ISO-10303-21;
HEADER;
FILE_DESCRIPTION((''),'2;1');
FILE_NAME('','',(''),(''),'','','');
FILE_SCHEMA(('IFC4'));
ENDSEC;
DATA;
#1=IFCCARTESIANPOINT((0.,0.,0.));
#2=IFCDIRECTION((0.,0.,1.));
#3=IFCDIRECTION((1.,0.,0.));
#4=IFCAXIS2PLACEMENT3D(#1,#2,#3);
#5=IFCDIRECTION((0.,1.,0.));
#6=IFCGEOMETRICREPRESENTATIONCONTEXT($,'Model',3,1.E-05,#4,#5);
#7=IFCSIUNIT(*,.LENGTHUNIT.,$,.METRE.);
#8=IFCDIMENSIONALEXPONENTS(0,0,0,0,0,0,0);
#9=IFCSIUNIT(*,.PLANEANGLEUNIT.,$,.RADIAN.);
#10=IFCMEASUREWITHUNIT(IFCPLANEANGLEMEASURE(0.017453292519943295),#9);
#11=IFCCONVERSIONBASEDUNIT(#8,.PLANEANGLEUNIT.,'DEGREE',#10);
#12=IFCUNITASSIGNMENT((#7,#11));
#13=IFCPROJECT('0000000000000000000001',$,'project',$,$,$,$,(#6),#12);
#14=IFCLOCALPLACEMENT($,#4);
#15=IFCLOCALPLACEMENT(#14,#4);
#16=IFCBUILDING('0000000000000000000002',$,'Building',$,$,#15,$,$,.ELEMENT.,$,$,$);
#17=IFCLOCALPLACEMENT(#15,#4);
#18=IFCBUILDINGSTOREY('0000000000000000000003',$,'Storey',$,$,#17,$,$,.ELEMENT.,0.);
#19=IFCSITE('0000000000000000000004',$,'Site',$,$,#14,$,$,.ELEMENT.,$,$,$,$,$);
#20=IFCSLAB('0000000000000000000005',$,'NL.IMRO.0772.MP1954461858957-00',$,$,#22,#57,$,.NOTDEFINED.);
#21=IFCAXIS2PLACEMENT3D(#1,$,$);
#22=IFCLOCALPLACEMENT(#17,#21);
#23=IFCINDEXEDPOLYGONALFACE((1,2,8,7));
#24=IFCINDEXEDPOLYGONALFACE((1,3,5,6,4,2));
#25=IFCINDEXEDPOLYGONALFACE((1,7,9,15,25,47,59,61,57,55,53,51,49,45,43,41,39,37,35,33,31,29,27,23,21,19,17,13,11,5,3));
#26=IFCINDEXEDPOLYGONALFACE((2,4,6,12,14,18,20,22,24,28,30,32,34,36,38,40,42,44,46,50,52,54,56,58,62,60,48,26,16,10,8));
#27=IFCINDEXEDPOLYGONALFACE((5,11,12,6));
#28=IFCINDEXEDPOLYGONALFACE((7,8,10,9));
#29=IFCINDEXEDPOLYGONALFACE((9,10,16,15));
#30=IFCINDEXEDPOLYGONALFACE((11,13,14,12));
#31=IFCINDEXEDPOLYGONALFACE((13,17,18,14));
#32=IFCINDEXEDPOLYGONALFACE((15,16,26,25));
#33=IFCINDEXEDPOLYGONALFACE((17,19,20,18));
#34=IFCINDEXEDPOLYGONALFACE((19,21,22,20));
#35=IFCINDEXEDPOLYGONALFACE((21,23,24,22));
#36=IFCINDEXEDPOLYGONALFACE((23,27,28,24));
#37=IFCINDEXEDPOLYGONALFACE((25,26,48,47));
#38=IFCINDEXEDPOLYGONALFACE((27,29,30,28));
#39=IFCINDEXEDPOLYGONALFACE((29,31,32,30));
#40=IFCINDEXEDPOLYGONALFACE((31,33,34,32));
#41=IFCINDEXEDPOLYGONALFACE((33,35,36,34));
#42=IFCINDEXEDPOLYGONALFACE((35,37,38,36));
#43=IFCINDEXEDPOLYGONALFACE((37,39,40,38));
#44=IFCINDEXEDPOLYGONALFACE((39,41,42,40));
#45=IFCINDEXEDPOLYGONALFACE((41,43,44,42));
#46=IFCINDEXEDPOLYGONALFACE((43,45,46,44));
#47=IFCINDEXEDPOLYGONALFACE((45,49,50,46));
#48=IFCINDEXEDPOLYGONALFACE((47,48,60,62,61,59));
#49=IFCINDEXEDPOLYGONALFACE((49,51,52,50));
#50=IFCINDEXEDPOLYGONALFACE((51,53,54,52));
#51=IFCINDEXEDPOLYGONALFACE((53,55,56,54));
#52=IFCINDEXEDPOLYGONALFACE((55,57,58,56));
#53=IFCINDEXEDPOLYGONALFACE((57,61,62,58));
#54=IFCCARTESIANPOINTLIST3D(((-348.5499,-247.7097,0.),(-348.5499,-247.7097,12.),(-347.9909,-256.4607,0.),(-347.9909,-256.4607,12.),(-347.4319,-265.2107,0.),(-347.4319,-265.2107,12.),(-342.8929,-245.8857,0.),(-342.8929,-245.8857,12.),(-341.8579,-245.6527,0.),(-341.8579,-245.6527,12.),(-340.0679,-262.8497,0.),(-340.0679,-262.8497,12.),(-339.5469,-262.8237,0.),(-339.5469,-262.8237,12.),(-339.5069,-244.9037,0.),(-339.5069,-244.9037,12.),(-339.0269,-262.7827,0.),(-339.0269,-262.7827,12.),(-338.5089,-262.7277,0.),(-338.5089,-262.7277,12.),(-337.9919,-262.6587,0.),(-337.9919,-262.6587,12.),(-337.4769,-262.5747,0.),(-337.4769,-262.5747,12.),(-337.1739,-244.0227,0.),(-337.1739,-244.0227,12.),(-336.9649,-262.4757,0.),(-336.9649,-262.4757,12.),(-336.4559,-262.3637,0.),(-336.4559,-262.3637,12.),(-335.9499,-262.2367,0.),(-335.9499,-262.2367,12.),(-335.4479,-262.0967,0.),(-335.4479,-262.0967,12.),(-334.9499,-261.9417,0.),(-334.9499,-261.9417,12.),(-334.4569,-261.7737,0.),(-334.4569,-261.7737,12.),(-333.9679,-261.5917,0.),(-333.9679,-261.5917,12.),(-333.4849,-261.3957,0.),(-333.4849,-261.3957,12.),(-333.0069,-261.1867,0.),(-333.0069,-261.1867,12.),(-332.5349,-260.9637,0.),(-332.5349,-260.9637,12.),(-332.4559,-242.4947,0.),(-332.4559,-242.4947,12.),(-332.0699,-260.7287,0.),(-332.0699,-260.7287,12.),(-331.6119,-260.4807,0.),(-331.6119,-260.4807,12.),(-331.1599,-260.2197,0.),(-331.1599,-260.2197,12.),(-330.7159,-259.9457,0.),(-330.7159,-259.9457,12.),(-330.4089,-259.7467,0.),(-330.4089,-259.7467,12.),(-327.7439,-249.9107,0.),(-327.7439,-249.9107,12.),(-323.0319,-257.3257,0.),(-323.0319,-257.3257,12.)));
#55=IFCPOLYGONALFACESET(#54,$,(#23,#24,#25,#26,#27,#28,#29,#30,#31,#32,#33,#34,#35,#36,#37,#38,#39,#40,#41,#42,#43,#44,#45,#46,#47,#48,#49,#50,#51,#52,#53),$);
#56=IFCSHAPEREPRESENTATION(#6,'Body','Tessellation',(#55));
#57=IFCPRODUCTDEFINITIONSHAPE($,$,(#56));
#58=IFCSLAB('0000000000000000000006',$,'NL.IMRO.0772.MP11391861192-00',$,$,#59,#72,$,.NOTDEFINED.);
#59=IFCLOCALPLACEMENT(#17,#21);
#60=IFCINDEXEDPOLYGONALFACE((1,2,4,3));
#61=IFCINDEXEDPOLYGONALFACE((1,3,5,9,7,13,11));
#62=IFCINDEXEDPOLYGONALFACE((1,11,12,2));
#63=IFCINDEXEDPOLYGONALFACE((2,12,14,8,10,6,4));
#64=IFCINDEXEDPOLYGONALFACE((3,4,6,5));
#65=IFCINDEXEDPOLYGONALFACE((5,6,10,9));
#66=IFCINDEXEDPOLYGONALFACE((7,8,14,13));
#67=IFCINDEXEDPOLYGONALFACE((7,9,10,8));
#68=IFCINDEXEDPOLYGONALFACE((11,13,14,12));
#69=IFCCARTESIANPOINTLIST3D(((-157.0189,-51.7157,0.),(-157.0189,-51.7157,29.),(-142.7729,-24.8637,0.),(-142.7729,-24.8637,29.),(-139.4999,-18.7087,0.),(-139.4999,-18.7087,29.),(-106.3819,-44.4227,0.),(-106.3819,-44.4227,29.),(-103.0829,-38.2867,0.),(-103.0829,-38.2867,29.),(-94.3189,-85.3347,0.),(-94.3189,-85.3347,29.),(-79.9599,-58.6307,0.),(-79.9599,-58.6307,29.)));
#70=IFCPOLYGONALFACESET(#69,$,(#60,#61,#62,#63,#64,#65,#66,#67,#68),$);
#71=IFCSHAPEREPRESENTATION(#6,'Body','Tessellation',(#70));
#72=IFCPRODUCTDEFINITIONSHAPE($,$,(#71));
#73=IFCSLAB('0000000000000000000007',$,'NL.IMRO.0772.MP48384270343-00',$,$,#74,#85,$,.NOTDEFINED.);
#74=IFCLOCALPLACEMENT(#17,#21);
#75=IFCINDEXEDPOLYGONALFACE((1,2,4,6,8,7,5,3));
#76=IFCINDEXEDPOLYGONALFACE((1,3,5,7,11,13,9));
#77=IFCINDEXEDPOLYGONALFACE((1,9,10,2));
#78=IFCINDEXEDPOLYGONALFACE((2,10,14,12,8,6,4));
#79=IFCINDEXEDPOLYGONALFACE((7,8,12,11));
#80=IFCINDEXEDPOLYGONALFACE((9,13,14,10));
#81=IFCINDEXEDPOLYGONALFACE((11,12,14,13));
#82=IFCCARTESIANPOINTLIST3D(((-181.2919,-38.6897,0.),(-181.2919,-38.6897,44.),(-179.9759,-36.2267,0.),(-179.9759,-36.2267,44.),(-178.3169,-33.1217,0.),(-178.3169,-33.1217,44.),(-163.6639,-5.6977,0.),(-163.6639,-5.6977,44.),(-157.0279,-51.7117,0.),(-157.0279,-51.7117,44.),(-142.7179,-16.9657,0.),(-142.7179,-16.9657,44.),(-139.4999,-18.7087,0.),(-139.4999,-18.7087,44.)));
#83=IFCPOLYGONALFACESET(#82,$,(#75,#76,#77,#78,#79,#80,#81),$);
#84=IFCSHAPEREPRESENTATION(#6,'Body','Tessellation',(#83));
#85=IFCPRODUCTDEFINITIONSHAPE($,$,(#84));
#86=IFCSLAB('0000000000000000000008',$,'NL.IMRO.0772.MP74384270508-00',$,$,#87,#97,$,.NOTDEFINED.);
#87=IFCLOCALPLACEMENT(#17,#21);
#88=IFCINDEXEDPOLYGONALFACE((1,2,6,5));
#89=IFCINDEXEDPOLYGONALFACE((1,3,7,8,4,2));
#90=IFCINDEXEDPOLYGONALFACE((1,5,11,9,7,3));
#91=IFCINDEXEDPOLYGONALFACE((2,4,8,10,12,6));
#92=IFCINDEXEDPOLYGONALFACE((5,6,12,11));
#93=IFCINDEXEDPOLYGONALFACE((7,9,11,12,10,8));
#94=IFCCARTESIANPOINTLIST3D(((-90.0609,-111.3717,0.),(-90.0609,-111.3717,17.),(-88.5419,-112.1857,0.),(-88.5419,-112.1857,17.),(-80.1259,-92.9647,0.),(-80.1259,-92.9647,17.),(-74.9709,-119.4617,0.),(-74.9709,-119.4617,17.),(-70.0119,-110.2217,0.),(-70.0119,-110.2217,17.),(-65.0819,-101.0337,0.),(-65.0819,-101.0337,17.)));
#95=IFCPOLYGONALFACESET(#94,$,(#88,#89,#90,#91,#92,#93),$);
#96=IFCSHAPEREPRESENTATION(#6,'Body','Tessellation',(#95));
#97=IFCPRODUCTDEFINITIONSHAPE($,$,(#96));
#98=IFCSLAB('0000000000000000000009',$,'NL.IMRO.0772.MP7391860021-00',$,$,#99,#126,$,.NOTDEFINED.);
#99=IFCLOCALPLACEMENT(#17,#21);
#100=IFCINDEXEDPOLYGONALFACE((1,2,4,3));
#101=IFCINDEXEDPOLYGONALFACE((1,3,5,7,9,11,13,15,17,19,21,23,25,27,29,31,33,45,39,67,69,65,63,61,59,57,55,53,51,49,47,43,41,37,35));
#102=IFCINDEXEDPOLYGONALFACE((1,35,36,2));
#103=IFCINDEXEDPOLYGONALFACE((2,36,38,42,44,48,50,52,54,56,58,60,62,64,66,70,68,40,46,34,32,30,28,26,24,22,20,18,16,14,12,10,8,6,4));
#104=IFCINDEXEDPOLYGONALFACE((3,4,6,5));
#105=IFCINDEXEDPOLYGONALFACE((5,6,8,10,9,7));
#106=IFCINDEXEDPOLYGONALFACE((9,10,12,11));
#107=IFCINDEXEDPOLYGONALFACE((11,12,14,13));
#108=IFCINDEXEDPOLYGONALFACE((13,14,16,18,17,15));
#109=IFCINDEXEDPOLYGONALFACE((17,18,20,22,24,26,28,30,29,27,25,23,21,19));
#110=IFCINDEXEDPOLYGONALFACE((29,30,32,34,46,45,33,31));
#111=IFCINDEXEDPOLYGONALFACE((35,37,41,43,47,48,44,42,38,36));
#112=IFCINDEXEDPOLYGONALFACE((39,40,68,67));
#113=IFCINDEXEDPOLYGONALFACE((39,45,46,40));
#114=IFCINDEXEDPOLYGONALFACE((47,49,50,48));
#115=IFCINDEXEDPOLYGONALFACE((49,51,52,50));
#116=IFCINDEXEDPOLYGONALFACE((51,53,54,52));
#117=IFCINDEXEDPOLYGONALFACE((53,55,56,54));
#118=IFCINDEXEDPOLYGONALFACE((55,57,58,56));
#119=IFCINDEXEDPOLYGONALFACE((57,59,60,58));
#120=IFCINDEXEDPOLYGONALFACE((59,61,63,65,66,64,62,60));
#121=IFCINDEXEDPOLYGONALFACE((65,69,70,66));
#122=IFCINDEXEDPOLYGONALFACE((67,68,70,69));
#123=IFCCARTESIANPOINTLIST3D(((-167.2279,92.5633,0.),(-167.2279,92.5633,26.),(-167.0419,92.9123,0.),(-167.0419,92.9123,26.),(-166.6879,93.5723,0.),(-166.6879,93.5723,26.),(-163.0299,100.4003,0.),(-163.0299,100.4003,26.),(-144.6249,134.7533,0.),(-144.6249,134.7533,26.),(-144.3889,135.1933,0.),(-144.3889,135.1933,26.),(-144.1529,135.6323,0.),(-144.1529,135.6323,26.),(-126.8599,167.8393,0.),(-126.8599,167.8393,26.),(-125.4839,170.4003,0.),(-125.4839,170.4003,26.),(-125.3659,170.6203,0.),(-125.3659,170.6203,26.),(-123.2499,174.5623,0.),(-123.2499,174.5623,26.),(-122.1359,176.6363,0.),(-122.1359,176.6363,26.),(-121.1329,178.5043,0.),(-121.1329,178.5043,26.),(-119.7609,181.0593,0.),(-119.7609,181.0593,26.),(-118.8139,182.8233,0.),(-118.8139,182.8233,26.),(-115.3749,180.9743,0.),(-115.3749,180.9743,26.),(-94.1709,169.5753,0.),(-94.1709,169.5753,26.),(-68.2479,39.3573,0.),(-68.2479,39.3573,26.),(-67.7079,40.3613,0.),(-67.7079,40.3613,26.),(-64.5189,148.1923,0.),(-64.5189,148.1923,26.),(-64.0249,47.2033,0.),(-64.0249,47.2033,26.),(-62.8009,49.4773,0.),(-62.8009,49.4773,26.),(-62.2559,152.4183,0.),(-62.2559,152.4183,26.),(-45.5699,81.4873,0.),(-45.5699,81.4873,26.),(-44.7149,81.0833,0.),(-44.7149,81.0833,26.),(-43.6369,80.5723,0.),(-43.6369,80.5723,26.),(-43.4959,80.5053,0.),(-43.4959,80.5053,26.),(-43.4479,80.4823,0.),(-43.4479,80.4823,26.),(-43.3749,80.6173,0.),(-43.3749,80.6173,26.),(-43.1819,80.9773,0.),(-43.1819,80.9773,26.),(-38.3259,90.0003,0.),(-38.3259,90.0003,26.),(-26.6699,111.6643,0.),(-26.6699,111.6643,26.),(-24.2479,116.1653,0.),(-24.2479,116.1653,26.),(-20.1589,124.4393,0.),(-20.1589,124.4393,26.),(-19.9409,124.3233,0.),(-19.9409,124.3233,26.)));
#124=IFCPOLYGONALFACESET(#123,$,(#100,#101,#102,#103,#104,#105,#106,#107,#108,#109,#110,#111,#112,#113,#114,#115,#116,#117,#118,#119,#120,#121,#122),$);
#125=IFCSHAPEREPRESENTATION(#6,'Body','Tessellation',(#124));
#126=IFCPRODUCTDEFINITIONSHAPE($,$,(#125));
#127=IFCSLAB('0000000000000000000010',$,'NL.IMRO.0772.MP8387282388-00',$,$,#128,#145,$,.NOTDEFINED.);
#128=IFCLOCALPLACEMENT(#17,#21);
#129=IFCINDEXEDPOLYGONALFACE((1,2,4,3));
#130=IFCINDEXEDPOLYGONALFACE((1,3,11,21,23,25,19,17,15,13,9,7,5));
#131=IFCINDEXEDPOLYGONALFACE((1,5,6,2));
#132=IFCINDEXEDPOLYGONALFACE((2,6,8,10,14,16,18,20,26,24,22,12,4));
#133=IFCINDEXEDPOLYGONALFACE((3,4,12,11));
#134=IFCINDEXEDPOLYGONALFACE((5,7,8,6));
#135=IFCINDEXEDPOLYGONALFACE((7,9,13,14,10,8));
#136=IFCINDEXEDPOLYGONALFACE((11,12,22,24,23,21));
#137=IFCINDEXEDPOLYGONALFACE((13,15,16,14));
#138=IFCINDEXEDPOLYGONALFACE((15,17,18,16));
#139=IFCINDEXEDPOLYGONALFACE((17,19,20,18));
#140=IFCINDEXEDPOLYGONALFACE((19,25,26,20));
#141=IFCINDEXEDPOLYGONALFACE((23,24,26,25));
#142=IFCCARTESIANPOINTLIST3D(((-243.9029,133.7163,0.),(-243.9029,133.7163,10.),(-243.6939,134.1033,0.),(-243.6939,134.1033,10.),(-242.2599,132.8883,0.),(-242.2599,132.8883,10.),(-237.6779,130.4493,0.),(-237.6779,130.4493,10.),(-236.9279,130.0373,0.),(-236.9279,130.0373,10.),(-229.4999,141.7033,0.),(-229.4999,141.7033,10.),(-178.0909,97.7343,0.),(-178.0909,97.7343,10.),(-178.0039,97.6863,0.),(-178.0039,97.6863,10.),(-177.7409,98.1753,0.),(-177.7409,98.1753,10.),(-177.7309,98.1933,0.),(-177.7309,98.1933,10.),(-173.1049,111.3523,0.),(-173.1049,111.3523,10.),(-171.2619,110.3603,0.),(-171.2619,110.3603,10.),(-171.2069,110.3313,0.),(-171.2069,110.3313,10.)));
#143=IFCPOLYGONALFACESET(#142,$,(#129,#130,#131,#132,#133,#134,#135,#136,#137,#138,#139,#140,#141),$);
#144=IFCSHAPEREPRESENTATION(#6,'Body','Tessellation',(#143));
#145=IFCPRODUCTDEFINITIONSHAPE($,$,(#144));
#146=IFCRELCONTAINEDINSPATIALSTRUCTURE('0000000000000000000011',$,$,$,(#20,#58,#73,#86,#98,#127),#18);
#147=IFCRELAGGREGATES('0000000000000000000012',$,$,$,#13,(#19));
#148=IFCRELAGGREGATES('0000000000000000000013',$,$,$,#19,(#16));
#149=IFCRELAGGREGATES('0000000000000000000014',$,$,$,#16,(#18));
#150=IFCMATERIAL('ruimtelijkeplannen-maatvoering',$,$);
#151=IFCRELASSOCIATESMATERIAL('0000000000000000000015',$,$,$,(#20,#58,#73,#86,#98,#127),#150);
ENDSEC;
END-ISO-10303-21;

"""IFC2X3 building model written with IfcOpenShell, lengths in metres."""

from ifc_helpers import new_model, entity, si_unit, converted_unit, direction, origin_with_axes, place, context, project, spatial, polyline, outline, extrude, material, element, save


model = new_model("IFC2X3")

# Units and contexts
model_context = context("Model", 3, precision=1e-05, world=origin_with_axes(), true_north=direction((0.0, 1.0, 0.0)))
ifc_project = project(units=[si_unit("LENGTHUNIT", "METRE"), converted_unit("PLANEANGLEUNIT", "DEGREE", entity("IfcPlaneAngleMeasure", 0.017453292519943295), si_unit("PLANEANGLEUNIT", "RADIAN"), dimensions=[0, 0, 0, 0, 0, 0, 0])], contexts=[model_context])

# Site, building, storey
site_placement = place(None, origin_with_axes())
site = spatial("IfcSite", under=ifc_project, at=site_placement, Name="Site", CompositionType="ELEMENT")
building_placement = place(site_placement, origin_with_axes())
building = spatial("IfcBuilding", under=site, at=building_placement, Name="Building", CompositionType="ELEMENT")
storey_placement = place(building_placement, origin_with_axes())
storey = spatial("IfcBuildingStorey", under=building, at=storey_placement, Name="Storey", CompositionType="ELEMENT", Elevation=0.0)

# Slabs
ifc_material = material(Name="ruimtelijkeplannen-maatvoering")
slab_1_placement = place(storey_placement, origin_with_axes())
element("IfcSlab", 1, at=slab_1_placement, inside=storey, material=ifc_material, Name="NL.IMRO.0772.MP1954461858957-00", PredefinedType="NOTDEFINED", context=model_context, shape_type="SweptSolid", body=[
    extrude(outline(polyline([(-331.6119, -260.4807), (-332.0699, -260.7287), (-332.5349, -260.9637), (-333.0069, -261.1867), (-333.4849, -261.3957), (-333.9679, -261.5917), (-334.4569, -261.7737), (-334.9499, -261.9417), (-335.4479, -262.0967), (-335.9499, -262.2367), (-336.4559, -262.3637), (-336.9649, -262.4757), (-337.4769, -262.5747), (-337.9919, -262.6587), (-338.5089, -262.7277), (-339.0269, -262.7827), (-339.5469, -262.8237), (-340.0679, -262.8497), (-347.4319, -265.2107), (-347.9909, -256.4607), (-348.5499, -247.7097), (-342.8929, -245.8857), (-341.8579, -245.6527), (-339.5069, -244.9037), (-337.1739, -244.0227), (-332.4559, -242.4947), (-327.7439, -249.9107), (-323.0319, -257.3257), (-330.4089, -259.7467), (-330.7159, -259.9457), (-331.1599, -260.2197), (-331.6119, -260.4807)])), origin_with_axes(), (0.0, 0.0, 1.0), 12.0),
])
slab_2_placement = place(storey_placement, origin_with_axes())
element("IfcSlab", 2, at=slab_2_placement, inside=storey, material=ifc_material, Name="NL.IMRO.0772.MP11391861192-00", PredefinedType="NOTDEFINED", context=model_context, shape_type="SweptSolid", body=[
    extrude(outline(polyline([(-142.7729, -24.8637), (-139.4999, -18.7087), (-103.0829, -38.2867), (-106.3819, -44.4227), (-79.9599, -58.6307), (-94.3189, -85.3347), (-157.0189, -51.7157), (-142.7729, -24.8637)])), origin_with_axes(), (0.0, 0.0, 1.0), 29.0),
])
slab_3_placement = place(storey_placement, origin_with_axes())
element("IfcSlab", 3, at=slab_3_placement, inside=storey, material=ifc_material, Name="NL.IMRO.0772.MP48384270343-00", PredefinedType="NOTDEFINED", context=model_context, shape_type="SweptSolid", body=[
    extrude(outline(polyline([(-157.0279, -51.7117), (-181.2919, -38.6897), (-179.9759, -36.2267), (-178.3169, -33.1217), (-163.6639, -5.6977), (-142.7179, -16.9657), (-139.4999, -18.7087), (-157.0279, -51.7117)])), origin_with_axes(), (0.0, 0.0, 1.0), 44.0),
])
slab_4_placement = place(storey_placement, origin_with_axes())
element("IfcSlab", 4, at=slab_4_placement, inside=storey, material=ifc_material, Name="NL.IMRO.0772.MP74384270508-00", PredefinedType="NOTDEFINED", context=model_context, shape_type="SweptSolid", body=[
    extrude(outline(polyline([(-65.0819, -101.0337), (-70.0119, -110.2217), (-74.9709, -119.4617), (-88.5419, -112.1857), (-90.0609, -111.3717), (-80.1259, -92.9647), (-65.0819, -101.0337)])), origin_with_axes(), (0.0, 0.0, 1.0), 17.0),
])
slab_5_placement = place(storey_placement, origin_with_axes())
element("IfcSlab", 5, at=slab_5_placement, inside=storey, material=ifc_material, Name="NL.IMRO.0772.MP7391860021-00", PredefinedType="NOTDEFINED", context=model_context, shape_type="SweptSolid", body=[
    extrude(outline(polyline([(-26.6699, 111.6643), (-38.3259, 90.0003), (-43.1819, 80.9773), (-43.3749, 80.6173), (-43.4479, 80.4823), (-43.4959, 80.5053), (-43.6369, 80.5723), (-44.7149, 81.0833), (-45.5699, 81.4873), (-62.8009, 49.4773), (-64.0249, 47.2033), (-67.7079, 40.3613), (-68.2479, 39.3573), (-167.2279, 92.5633), (-167.0419, 92.9123), (-166.6879, 93.5723), (-163.0299, 100.4003), (-144.6249, 134.7533), (-144.3889, 135.1933), (-144.1529, 135.6323), (-126.8599, 167.8393), (-125.4839, 170.4003), (-125.3659, 170.6203), (-123.2499, 174.5623), (-122.1359, 176.6363), (-121.1329, 178.5043), (-119.7609, 181.0593), (-118.8139, 182.8233), (-115.3749, 180.9743), (-94.1709, 169.5753), (-62.2559, 152.4183), (-64.5189, 148.1923), (-20.1589, 124.4393), (-19.9409, 124.3233), (-24.2479, 116.1653), (-26.6699, 111.6643)])), origin_with_axes(), (0.0, 0.0, 1.0), 26.0),
])
slab_6_placement = place(storey_placement, origin_with_axes())
element("IfcSlab", 6, at=slab_6_placement, inside=storey, material=ifc_material, Name="NL.IMRO.0772.MP8387282388-00", PredefinedType="NOTDEFINED", context=model_context, shape_type="SweptSolid", body=[
    extrude(outline(polyline([(-171.2069, 110.3313), (-177.7309, 98.1933), (-177.7409, 98.1753), (-178.0039, 97.6863), (-178.0909, 97.7343), (-236.9279, 130.0373), (-237.6779, 130.4493), (-242.2599, 132.8883), (-243.9029, 133.7163), (-243.6939, 134.1033), (-229.4999, 141.7033), (-173.1049, 111.3523), (-171.2619, 110.3603), (-171.2069, 110.3313)])), origin_with_axes(), (0.0, 0.0, 1.0), 10.0),
])

save(model, "model.ifc")
